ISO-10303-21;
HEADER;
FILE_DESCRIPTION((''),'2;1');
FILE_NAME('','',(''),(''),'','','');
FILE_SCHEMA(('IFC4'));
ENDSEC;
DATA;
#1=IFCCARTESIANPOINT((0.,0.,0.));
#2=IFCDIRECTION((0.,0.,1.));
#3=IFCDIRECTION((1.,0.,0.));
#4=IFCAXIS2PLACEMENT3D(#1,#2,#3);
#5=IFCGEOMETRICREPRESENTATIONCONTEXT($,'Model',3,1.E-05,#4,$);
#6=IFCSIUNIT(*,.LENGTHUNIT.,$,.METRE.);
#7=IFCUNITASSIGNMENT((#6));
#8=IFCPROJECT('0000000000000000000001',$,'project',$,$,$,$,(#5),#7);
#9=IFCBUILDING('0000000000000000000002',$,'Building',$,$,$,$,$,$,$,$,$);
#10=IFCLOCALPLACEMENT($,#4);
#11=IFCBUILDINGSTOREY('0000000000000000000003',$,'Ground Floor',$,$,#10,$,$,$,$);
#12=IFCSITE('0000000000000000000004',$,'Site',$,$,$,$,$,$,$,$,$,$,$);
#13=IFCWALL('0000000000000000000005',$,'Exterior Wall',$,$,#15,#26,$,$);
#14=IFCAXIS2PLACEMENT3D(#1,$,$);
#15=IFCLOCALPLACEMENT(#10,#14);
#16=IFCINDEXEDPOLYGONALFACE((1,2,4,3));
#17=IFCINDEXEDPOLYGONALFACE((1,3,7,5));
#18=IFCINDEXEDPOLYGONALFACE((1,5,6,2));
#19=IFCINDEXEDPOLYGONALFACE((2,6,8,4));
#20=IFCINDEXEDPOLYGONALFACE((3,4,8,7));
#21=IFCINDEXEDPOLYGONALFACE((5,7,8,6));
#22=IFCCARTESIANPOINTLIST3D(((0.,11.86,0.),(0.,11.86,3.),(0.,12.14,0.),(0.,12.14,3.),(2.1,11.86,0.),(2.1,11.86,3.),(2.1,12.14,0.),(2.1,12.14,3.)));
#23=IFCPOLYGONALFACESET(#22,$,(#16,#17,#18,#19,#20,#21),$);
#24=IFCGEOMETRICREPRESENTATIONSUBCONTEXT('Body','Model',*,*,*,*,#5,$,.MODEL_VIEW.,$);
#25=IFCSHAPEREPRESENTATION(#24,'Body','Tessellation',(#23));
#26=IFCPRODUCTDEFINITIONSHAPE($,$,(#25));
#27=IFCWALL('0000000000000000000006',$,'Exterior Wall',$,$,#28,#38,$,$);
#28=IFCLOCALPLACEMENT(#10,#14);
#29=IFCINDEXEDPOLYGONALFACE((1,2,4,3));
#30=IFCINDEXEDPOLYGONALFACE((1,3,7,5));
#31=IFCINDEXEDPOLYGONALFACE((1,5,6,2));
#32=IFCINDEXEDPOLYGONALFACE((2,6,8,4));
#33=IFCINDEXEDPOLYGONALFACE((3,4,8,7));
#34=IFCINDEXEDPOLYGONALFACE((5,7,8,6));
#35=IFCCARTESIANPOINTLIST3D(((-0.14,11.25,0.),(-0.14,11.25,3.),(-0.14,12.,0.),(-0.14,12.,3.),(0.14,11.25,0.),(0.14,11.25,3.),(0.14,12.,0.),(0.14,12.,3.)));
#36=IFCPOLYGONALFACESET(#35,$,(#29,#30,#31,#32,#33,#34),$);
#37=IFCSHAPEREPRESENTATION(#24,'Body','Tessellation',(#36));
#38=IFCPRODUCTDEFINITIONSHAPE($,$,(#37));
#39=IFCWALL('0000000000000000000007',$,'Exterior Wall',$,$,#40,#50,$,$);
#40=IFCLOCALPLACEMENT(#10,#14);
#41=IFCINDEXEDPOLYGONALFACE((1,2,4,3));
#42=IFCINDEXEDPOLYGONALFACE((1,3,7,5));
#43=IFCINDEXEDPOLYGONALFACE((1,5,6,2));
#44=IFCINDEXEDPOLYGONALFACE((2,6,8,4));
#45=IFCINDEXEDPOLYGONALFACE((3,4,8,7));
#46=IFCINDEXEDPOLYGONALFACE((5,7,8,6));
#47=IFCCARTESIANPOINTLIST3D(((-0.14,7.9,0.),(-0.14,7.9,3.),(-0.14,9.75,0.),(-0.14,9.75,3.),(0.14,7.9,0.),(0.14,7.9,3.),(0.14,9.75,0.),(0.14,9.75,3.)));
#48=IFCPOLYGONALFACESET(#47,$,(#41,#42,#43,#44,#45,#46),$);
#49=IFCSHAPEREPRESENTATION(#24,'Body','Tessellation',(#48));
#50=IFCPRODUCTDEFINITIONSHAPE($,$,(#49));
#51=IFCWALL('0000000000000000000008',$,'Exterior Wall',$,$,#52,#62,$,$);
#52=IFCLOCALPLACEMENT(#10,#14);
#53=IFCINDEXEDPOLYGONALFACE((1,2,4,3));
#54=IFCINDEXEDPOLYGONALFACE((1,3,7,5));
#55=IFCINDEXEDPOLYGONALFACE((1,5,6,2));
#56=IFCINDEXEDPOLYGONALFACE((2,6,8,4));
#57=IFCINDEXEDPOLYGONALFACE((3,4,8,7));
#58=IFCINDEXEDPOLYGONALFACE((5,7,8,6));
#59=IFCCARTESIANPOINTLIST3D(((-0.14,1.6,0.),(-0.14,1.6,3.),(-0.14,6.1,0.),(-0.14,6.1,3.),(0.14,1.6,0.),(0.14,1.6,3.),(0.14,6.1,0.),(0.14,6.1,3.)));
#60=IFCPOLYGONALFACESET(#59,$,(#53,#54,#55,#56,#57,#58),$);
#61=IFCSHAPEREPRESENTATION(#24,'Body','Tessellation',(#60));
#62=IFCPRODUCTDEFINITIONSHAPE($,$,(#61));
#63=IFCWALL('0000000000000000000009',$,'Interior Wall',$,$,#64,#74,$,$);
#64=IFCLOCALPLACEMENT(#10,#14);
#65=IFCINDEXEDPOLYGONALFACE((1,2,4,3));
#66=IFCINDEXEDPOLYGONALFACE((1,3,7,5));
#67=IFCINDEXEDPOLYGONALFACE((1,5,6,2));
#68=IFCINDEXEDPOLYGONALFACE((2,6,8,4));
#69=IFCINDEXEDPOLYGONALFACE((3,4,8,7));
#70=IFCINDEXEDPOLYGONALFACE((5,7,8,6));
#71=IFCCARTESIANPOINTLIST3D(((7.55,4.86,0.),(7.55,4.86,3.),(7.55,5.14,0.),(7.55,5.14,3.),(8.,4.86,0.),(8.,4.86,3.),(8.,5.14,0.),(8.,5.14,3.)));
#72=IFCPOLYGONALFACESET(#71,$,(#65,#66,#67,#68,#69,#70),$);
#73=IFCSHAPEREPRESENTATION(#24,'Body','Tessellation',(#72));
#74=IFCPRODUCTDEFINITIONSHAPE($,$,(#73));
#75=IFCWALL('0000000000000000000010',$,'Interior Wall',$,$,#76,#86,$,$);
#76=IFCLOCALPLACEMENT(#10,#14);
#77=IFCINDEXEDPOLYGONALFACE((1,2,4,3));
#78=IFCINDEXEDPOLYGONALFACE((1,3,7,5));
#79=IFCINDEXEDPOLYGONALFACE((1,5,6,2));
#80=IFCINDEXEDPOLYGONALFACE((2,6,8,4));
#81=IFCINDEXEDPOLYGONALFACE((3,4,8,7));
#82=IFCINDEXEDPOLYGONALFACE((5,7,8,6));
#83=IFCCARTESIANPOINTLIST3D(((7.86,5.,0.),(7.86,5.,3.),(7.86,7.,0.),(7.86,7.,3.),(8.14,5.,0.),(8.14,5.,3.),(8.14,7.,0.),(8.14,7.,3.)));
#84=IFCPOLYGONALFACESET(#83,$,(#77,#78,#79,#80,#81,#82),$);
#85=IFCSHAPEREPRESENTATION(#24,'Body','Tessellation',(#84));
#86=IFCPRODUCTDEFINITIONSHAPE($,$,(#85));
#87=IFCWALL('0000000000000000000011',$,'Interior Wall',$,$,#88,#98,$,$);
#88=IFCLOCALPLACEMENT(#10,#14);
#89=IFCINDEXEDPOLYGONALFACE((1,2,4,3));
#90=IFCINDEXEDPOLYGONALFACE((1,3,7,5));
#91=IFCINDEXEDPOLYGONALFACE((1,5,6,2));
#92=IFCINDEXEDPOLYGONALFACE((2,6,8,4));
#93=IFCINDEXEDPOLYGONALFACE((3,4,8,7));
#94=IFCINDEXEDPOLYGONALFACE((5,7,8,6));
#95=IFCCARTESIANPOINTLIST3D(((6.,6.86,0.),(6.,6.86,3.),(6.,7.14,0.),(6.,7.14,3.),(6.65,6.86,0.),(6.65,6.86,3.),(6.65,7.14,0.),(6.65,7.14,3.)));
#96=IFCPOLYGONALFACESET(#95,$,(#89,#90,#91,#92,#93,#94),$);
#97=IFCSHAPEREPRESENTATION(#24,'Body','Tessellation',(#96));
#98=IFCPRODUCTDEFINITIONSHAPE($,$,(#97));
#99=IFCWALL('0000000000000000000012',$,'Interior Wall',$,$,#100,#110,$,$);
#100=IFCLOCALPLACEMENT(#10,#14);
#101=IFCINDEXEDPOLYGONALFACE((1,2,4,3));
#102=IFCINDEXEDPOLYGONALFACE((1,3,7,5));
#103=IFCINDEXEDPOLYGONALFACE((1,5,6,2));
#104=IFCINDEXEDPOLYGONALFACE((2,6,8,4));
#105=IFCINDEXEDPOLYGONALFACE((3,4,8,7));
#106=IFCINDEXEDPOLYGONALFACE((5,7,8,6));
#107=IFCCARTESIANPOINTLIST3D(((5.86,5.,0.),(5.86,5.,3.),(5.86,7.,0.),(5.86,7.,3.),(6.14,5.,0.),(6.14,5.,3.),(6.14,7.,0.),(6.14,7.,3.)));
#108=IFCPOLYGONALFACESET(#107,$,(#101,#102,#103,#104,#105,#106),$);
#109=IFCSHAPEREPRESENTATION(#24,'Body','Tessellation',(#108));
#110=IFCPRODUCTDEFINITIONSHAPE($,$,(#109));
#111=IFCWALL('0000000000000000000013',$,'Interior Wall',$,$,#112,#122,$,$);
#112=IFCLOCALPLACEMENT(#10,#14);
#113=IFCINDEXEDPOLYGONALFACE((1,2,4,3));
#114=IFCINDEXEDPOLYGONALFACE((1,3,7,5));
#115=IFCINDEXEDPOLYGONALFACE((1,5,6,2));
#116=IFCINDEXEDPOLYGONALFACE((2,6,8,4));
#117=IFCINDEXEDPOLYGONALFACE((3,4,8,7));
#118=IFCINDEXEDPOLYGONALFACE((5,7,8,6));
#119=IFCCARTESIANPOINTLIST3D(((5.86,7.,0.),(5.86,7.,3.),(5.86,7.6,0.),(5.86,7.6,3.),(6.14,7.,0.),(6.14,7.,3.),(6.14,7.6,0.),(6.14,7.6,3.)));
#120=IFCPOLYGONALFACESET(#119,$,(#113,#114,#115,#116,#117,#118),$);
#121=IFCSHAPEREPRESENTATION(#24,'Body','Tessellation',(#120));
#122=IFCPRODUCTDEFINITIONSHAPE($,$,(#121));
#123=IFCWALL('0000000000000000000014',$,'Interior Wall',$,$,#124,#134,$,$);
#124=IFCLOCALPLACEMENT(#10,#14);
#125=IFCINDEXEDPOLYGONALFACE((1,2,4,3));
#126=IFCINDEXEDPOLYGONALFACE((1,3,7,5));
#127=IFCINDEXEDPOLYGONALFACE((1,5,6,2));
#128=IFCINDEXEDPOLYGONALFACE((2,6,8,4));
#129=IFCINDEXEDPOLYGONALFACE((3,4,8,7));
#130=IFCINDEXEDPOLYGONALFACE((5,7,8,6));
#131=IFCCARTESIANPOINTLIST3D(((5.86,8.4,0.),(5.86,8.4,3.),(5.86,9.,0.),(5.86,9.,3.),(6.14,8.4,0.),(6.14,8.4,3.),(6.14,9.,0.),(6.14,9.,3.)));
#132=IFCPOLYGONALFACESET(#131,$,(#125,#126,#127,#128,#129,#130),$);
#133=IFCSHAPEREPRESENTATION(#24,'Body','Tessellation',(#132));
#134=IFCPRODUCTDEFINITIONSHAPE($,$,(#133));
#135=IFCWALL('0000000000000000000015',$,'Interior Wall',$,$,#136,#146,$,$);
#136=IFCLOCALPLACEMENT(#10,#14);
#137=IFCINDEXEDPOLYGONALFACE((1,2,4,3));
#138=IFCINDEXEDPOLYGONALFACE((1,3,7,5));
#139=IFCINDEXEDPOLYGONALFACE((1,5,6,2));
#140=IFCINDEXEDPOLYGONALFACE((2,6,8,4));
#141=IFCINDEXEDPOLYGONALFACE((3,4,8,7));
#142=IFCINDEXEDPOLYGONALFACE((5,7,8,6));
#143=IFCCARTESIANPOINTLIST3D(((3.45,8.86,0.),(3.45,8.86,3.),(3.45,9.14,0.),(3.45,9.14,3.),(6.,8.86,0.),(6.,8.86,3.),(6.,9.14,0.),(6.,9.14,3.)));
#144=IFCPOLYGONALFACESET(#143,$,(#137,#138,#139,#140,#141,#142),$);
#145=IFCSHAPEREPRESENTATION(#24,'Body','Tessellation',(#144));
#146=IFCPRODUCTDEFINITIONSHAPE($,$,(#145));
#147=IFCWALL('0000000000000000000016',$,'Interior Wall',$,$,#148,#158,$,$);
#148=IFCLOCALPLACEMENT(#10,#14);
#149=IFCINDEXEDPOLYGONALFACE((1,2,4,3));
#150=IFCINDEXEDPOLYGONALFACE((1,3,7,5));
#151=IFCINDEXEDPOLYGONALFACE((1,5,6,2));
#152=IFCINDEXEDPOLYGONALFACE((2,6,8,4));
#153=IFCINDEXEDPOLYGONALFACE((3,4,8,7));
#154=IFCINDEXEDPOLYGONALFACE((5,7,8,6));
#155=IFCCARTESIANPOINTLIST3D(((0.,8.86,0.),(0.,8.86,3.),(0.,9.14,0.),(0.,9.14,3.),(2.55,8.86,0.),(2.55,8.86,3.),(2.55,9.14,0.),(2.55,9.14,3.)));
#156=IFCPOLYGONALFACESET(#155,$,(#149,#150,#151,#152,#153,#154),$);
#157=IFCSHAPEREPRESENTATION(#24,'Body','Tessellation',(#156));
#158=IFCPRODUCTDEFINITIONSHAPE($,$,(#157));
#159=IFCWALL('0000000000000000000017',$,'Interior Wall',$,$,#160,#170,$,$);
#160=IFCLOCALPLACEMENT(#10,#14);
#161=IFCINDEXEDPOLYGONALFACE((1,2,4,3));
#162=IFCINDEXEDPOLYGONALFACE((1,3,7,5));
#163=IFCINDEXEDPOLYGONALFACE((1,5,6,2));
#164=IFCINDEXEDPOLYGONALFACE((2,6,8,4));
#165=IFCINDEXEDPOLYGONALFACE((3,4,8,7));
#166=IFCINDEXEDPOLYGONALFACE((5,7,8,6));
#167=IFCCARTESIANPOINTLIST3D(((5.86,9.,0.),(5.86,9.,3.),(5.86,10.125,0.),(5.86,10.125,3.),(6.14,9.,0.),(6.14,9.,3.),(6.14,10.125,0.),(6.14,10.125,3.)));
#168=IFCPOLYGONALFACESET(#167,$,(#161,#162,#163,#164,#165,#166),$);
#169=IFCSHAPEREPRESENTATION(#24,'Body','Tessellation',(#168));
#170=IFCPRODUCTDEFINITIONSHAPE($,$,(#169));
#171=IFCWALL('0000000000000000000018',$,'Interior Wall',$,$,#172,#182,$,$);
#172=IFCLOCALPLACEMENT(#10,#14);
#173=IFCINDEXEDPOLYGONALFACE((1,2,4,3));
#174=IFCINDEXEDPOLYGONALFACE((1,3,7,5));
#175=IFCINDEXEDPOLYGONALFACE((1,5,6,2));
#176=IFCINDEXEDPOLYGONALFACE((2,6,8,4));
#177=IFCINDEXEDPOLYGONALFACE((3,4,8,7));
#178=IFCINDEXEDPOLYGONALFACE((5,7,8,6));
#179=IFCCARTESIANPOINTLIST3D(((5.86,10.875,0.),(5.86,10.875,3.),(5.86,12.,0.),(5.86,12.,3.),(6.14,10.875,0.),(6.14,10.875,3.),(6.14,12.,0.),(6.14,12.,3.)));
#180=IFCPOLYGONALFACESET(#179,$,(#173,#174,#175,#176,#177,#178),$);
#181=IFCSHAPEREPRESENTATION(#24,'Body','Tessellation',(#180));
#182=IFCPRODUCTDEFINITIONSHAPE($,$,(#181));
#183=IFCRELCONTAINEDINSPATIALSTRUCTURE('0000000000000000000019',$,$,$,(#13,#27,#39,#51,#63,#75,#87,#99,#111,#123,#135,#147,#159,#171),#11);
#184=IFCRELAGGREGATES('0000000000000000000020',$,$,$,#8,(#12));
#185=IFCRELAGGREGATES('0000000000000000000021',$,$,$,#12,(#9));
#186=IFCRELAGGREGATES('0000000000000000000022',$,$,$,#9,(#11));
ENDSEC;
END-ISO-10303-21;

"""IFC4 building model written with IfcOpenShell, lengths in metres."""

from ifc_helpers import new_model, si_unit, frame, origin_with_axes, place, context, subcontext, project, spatial, indexed_curve, outline, extrude, element, save


model = new_model("IFC4")

# Units and contexts
model_context = context("Model", 3, precision=1e-05, world=origin_with_axes())
body_context = subcontext(model_context, "Body", "Model", "MODEL_VIEW")
ifc_project = project(units=[si_unit("LENGTHUNIT", "METRE")], contexts=[model_context])

# Site, building, storey
site = spatial("IfcSite", under=ifc_project, Name="Site")
building = spatial("IfcBuilding", under=site, Name="Building")
storey_placement = place(None, origin_with_axes())
storey = spatial("IfcBuildingStorey", under=building, at=storey_placement, Name="Ground Floor")

# Walls
wall_1_placement = place(storey_placement, frame((2.1, 12.0, 0.0), z_axis=(0.0, 0.0, 1.0), x_axis=(-1.0, 0.0, 0.0)))
element("IfcWall", 1, at=wall_1_placement, inside=storey, Name="Exterior Wall", context=body_context, shape_type="SweptSolid", body=[
    extrude(outline(indexed_curve([(0.0, 0.0), (0.0, 0.28), (2.1, 0.28), (2.1, 0.0), (0.0, 0.0)], self_intersect=False)), frame((0.0, -0.14, 0.0), z_axis=(0.0, 0.0, 1.0), x_axis=(1.0, 0.0, 0.0)), (0.0, 0.0, 1.0), 3.0),
])
wall_2_placement = place(storey_placement, frame((0.0, 12.0, 0.0), z_axis=(0.0, 0.0, 1.0), x_axis=(0.0, -1.0, 0.0)))
element("IfcWall", 2, at=wall_2_placement, inside=storey, Name="Exterior Wall", context=body_context, shape_type="SweptSolid", body=[
    extrude(outline(indexed_curve([(0.0, 0.0), (0.0, 0.28), (0.75, 0.28), (0.75, 0.0), (0.0, 0.0)], self_intersect=False)), frame((0.0, -0.14, 0.0), z_axis=(0.0, 0.0, 1.0), x_axis=(1.0, 0.0, 0.0)), (0.0, 0.0, 1.0), 3.0),
])
wall_3_placement = place(storey_placement, frame((0.0, 9.75, 0.0), z_axis=(0.0, 0.0, 1.0), x_axis=(0.0, -1.0, 0.0)))
element("IfcWall", 3, at=wall_3_placement, inside=storey, Name="Exterior Wall", context=body_context, shape_type="SweptSolid", body=[
    extrude(outline(indexed_curve([(0.0, 0.0), (0.0, 0.28), (1.85, 0.28), (1.85, 0.0), (0.0, 0.0)], self_intersect=False)), frame((0.0, -0.14, 0.0), z_axis=(0.0, 0.0, 1.0), x_axis=(1.0, 0.0, 0.0)), (0.0, 0.0, 1.0), 3.0),
])
wall_4_placement = place(storey_placement, frame((0.0, 6.1, 0.0), z_axis=(0.0, 0.0, 1.0), x_axis=(0.0, -1.0, 0.0)))
element("IfcWall", 4, at=wall_4_placement, inside=storey, Name="Exterior Wall", context=body_context, shape_type="SweptSolid", body=[
    extrude(outline(indexed_curve([(0.0, 0.0), (0.0, 0.28), (4.5, 0.28), (4.5, 0.0), (0.0, 0.0)], self_intersect=False)), frame((0.0, -0.14, 0.0), z_axis=(0.0, 0.0, 1.0), x_axis=(1.0, 0.0, 0.0)), (0.0, 0.0, 1.0), 3.0),
])
wall_5_placement = place(storey_placement, frame((8.0, 5.0, 0.0), z_axis=(0.0, 0.0, 1.0), x_axis=(-1.0, 0.0, 0.0)))
element("IfcWall", 5, at=wall_5_placement, inside=storey, Name="Interior Wall", context=body_context, shape_type="SweptSolid", body=[
    extrude(outline(indexed_curve([(0.0, 0.0), (0.0, 0.28), (0.45, 0.28), (0.45, 0.0), (0.0, 0.0)], self_intersect=False)), frame((0.0, -0.14, 0.0), z_axis=(0.0, 0.0, 1.0), x_axis=(1.0, 0.0, 0.0)), (0.0, 0.0, 1.0), 3.0),
])
wall_6_placement = place(storey_placement, frame((8.0, 5.0, 0.0), z_axis=(0.0, 0.0, 1.0), x_axis=(0.0, 1.0, 0.0)))
element("IfcWall", 6, at=wall_6_placement, inside=storey, Name="Interior Wall", context=body_context, shape_type="SweptSolid", body=[
    extrude(outline(indexed_curve([(0.0, 0.0), (0.0, 0.28), (2.0, 0.28), (2.0, 0.0), (0.0, 0.0)], self_intersect=False)), frame((0.0, -0.14, 0.0), z_axis=(0.0, 0.0, 1.0), x_axis=(1.0, 0.0, 0.0)), (0.0, 0.0, 1.0), 3.0),
])
wall_7_placement = place(storey_placement, frame((6.65, 7.0, 0.0), z_axis=(0.0, 0.0, 1.0), x_axis=(-1.0, 0.0, 0.0)))
element("IfcWall", 7, at=wall_7_placement, inside=storey, Name="Interior Wall", context=body_context, shape_type="SweptSolid", body=[
    extrude(outline(indexed_curve([(0.0, 0.0), (0.0, 0.28), (0.65, 0.28), (0.65, 0.0), (0.0, 0.0)], self_intersect=False)), frame((0.0, -0.14, 0.0), z_axis=(0.0, 0.0, 1.0), x_axis=(1.0, 0.0, 0.0)), (0.0, 0.0, 1.0), 3.0),
])
wall_8_placement = place(storey_placement, frame((6.0, 7.0, 0.0), z_axis=(0.0, 0.0, 1.0), x_axis=(0.0, -1.0, 0.0)))
element("IfcWall", 8, at=wall_8_placement, inside=storey, Name="Interior Wall", context=body_context, shape_type="SweptSolid", body=[
    extrude(outline(indexed_curve([(0.0, 0.0), (0.0, 0.28), (2.0, 0.28), (2.0, 0.0), (0.0, 0.0)], self_intersect=False)), frame((0.0, -0.14, 0.0), z_axis=(0.0, 0.0, 1.0), x_axis=(1.0, 0.0, 0.0)), (0.0, 0.0, 1.0), 3.0),
])
for number, where, z_axis, x_axis, name in (
    (9, (6.0, 7.0, 0.0), (0.0, 0.0, 1.0), (0.0, 1.0, 0.0), "Interior Wall"),
    (10, (6.0, 8.4, 0.0), (0.0, 0.0, 1.0), (0.0, 1.0, 0.0), "Interior Wall"),
):
    element("IfcWall", number, at=place(storey_placement, frame(where, z_axis=z_axis, x_axis=x_axis)), inside=storey, Name=name, context=body_context, shape_type="SweptSolid", body=[
        extrude(outline(indexed_curve([(0.0, 0.0), (0.0, 0.28), (0.6, 0.28), (0.6, 0.0), (0.0, 0.0)], self_intersect=False)), frame((0.0, -0.14, 0.0), z_axis=(0.0, 0.0, 1.0), x_axis=(1.0, 0.0, 0.0)), (0.0, 0.0, 1.0), 3.0),
    ])
for number, where, z_axis, x_axis, name in (
    (11, (6.0, 9.0, 0.0), (0.0, 0.0, 1.0), (-1.0, 0.0, 0.0), "Interior Wall"),
    (12, (2.55, 9.0, 0.0), (0.0, 0.0, 1.0), (-1.0, 0.0, 0.0), "Interior Wall"),
):
    element("IfcWall", number, at=place(storey_placement, frame(where, z_axis=z_axis, x_axis=x_axis)), inside=storey, Name=name, context=body_context, shape_type="SweptSolid", body=[
        extrude(outline(indexed_curve([(0.0, 0.0), (0.0, 0.28), (2.55, 0.28), (2.55, 0.0), (0.0, 0.0)], self_intersect=False)), frame((0.0, -0.14, 0.0), z_axis=(0.0, 0.0, 1.0), x_axis=(1.0, 0.0, 0.0)), (0.0, 0.0, 1.0), 3.0),
    ])
for number, where, z_axis, x_axis, name in (
    (13, (6.0, 9.0, 0.0), (0.0, 0.0, 1.0), (0.0, 1.0, 0.0), "Interior Wall"),
    (14, (6.0, 10.875, 0.0), (0.0, 0.0, 1.0), (0.0, 1.0, 0.0), "Interior Wall"),
):
    element("IfcWall", number, at=place(storey_placement, frame(where, z_axis=z_axis, x_axis=x_axis)), inside=storey, Name=name, context=body_context, shape_type="SweptSolid", body=[
        extrude(outline(indexed_curve([(0.0, 0.0), (0.0, 0.28), (1.125, 0.28), (1.125, 0.0), (0.0, 0.0)], self_intersect=False)), frame((0.0, -0.14, 0.0), z_axis=(0.0, 0.0, 1.0), x_axis=(1.0, 0.0, 0.0)), (0.0, 0.0, 1.0), 3.0),
    ])

save(model, "model.ifc")
